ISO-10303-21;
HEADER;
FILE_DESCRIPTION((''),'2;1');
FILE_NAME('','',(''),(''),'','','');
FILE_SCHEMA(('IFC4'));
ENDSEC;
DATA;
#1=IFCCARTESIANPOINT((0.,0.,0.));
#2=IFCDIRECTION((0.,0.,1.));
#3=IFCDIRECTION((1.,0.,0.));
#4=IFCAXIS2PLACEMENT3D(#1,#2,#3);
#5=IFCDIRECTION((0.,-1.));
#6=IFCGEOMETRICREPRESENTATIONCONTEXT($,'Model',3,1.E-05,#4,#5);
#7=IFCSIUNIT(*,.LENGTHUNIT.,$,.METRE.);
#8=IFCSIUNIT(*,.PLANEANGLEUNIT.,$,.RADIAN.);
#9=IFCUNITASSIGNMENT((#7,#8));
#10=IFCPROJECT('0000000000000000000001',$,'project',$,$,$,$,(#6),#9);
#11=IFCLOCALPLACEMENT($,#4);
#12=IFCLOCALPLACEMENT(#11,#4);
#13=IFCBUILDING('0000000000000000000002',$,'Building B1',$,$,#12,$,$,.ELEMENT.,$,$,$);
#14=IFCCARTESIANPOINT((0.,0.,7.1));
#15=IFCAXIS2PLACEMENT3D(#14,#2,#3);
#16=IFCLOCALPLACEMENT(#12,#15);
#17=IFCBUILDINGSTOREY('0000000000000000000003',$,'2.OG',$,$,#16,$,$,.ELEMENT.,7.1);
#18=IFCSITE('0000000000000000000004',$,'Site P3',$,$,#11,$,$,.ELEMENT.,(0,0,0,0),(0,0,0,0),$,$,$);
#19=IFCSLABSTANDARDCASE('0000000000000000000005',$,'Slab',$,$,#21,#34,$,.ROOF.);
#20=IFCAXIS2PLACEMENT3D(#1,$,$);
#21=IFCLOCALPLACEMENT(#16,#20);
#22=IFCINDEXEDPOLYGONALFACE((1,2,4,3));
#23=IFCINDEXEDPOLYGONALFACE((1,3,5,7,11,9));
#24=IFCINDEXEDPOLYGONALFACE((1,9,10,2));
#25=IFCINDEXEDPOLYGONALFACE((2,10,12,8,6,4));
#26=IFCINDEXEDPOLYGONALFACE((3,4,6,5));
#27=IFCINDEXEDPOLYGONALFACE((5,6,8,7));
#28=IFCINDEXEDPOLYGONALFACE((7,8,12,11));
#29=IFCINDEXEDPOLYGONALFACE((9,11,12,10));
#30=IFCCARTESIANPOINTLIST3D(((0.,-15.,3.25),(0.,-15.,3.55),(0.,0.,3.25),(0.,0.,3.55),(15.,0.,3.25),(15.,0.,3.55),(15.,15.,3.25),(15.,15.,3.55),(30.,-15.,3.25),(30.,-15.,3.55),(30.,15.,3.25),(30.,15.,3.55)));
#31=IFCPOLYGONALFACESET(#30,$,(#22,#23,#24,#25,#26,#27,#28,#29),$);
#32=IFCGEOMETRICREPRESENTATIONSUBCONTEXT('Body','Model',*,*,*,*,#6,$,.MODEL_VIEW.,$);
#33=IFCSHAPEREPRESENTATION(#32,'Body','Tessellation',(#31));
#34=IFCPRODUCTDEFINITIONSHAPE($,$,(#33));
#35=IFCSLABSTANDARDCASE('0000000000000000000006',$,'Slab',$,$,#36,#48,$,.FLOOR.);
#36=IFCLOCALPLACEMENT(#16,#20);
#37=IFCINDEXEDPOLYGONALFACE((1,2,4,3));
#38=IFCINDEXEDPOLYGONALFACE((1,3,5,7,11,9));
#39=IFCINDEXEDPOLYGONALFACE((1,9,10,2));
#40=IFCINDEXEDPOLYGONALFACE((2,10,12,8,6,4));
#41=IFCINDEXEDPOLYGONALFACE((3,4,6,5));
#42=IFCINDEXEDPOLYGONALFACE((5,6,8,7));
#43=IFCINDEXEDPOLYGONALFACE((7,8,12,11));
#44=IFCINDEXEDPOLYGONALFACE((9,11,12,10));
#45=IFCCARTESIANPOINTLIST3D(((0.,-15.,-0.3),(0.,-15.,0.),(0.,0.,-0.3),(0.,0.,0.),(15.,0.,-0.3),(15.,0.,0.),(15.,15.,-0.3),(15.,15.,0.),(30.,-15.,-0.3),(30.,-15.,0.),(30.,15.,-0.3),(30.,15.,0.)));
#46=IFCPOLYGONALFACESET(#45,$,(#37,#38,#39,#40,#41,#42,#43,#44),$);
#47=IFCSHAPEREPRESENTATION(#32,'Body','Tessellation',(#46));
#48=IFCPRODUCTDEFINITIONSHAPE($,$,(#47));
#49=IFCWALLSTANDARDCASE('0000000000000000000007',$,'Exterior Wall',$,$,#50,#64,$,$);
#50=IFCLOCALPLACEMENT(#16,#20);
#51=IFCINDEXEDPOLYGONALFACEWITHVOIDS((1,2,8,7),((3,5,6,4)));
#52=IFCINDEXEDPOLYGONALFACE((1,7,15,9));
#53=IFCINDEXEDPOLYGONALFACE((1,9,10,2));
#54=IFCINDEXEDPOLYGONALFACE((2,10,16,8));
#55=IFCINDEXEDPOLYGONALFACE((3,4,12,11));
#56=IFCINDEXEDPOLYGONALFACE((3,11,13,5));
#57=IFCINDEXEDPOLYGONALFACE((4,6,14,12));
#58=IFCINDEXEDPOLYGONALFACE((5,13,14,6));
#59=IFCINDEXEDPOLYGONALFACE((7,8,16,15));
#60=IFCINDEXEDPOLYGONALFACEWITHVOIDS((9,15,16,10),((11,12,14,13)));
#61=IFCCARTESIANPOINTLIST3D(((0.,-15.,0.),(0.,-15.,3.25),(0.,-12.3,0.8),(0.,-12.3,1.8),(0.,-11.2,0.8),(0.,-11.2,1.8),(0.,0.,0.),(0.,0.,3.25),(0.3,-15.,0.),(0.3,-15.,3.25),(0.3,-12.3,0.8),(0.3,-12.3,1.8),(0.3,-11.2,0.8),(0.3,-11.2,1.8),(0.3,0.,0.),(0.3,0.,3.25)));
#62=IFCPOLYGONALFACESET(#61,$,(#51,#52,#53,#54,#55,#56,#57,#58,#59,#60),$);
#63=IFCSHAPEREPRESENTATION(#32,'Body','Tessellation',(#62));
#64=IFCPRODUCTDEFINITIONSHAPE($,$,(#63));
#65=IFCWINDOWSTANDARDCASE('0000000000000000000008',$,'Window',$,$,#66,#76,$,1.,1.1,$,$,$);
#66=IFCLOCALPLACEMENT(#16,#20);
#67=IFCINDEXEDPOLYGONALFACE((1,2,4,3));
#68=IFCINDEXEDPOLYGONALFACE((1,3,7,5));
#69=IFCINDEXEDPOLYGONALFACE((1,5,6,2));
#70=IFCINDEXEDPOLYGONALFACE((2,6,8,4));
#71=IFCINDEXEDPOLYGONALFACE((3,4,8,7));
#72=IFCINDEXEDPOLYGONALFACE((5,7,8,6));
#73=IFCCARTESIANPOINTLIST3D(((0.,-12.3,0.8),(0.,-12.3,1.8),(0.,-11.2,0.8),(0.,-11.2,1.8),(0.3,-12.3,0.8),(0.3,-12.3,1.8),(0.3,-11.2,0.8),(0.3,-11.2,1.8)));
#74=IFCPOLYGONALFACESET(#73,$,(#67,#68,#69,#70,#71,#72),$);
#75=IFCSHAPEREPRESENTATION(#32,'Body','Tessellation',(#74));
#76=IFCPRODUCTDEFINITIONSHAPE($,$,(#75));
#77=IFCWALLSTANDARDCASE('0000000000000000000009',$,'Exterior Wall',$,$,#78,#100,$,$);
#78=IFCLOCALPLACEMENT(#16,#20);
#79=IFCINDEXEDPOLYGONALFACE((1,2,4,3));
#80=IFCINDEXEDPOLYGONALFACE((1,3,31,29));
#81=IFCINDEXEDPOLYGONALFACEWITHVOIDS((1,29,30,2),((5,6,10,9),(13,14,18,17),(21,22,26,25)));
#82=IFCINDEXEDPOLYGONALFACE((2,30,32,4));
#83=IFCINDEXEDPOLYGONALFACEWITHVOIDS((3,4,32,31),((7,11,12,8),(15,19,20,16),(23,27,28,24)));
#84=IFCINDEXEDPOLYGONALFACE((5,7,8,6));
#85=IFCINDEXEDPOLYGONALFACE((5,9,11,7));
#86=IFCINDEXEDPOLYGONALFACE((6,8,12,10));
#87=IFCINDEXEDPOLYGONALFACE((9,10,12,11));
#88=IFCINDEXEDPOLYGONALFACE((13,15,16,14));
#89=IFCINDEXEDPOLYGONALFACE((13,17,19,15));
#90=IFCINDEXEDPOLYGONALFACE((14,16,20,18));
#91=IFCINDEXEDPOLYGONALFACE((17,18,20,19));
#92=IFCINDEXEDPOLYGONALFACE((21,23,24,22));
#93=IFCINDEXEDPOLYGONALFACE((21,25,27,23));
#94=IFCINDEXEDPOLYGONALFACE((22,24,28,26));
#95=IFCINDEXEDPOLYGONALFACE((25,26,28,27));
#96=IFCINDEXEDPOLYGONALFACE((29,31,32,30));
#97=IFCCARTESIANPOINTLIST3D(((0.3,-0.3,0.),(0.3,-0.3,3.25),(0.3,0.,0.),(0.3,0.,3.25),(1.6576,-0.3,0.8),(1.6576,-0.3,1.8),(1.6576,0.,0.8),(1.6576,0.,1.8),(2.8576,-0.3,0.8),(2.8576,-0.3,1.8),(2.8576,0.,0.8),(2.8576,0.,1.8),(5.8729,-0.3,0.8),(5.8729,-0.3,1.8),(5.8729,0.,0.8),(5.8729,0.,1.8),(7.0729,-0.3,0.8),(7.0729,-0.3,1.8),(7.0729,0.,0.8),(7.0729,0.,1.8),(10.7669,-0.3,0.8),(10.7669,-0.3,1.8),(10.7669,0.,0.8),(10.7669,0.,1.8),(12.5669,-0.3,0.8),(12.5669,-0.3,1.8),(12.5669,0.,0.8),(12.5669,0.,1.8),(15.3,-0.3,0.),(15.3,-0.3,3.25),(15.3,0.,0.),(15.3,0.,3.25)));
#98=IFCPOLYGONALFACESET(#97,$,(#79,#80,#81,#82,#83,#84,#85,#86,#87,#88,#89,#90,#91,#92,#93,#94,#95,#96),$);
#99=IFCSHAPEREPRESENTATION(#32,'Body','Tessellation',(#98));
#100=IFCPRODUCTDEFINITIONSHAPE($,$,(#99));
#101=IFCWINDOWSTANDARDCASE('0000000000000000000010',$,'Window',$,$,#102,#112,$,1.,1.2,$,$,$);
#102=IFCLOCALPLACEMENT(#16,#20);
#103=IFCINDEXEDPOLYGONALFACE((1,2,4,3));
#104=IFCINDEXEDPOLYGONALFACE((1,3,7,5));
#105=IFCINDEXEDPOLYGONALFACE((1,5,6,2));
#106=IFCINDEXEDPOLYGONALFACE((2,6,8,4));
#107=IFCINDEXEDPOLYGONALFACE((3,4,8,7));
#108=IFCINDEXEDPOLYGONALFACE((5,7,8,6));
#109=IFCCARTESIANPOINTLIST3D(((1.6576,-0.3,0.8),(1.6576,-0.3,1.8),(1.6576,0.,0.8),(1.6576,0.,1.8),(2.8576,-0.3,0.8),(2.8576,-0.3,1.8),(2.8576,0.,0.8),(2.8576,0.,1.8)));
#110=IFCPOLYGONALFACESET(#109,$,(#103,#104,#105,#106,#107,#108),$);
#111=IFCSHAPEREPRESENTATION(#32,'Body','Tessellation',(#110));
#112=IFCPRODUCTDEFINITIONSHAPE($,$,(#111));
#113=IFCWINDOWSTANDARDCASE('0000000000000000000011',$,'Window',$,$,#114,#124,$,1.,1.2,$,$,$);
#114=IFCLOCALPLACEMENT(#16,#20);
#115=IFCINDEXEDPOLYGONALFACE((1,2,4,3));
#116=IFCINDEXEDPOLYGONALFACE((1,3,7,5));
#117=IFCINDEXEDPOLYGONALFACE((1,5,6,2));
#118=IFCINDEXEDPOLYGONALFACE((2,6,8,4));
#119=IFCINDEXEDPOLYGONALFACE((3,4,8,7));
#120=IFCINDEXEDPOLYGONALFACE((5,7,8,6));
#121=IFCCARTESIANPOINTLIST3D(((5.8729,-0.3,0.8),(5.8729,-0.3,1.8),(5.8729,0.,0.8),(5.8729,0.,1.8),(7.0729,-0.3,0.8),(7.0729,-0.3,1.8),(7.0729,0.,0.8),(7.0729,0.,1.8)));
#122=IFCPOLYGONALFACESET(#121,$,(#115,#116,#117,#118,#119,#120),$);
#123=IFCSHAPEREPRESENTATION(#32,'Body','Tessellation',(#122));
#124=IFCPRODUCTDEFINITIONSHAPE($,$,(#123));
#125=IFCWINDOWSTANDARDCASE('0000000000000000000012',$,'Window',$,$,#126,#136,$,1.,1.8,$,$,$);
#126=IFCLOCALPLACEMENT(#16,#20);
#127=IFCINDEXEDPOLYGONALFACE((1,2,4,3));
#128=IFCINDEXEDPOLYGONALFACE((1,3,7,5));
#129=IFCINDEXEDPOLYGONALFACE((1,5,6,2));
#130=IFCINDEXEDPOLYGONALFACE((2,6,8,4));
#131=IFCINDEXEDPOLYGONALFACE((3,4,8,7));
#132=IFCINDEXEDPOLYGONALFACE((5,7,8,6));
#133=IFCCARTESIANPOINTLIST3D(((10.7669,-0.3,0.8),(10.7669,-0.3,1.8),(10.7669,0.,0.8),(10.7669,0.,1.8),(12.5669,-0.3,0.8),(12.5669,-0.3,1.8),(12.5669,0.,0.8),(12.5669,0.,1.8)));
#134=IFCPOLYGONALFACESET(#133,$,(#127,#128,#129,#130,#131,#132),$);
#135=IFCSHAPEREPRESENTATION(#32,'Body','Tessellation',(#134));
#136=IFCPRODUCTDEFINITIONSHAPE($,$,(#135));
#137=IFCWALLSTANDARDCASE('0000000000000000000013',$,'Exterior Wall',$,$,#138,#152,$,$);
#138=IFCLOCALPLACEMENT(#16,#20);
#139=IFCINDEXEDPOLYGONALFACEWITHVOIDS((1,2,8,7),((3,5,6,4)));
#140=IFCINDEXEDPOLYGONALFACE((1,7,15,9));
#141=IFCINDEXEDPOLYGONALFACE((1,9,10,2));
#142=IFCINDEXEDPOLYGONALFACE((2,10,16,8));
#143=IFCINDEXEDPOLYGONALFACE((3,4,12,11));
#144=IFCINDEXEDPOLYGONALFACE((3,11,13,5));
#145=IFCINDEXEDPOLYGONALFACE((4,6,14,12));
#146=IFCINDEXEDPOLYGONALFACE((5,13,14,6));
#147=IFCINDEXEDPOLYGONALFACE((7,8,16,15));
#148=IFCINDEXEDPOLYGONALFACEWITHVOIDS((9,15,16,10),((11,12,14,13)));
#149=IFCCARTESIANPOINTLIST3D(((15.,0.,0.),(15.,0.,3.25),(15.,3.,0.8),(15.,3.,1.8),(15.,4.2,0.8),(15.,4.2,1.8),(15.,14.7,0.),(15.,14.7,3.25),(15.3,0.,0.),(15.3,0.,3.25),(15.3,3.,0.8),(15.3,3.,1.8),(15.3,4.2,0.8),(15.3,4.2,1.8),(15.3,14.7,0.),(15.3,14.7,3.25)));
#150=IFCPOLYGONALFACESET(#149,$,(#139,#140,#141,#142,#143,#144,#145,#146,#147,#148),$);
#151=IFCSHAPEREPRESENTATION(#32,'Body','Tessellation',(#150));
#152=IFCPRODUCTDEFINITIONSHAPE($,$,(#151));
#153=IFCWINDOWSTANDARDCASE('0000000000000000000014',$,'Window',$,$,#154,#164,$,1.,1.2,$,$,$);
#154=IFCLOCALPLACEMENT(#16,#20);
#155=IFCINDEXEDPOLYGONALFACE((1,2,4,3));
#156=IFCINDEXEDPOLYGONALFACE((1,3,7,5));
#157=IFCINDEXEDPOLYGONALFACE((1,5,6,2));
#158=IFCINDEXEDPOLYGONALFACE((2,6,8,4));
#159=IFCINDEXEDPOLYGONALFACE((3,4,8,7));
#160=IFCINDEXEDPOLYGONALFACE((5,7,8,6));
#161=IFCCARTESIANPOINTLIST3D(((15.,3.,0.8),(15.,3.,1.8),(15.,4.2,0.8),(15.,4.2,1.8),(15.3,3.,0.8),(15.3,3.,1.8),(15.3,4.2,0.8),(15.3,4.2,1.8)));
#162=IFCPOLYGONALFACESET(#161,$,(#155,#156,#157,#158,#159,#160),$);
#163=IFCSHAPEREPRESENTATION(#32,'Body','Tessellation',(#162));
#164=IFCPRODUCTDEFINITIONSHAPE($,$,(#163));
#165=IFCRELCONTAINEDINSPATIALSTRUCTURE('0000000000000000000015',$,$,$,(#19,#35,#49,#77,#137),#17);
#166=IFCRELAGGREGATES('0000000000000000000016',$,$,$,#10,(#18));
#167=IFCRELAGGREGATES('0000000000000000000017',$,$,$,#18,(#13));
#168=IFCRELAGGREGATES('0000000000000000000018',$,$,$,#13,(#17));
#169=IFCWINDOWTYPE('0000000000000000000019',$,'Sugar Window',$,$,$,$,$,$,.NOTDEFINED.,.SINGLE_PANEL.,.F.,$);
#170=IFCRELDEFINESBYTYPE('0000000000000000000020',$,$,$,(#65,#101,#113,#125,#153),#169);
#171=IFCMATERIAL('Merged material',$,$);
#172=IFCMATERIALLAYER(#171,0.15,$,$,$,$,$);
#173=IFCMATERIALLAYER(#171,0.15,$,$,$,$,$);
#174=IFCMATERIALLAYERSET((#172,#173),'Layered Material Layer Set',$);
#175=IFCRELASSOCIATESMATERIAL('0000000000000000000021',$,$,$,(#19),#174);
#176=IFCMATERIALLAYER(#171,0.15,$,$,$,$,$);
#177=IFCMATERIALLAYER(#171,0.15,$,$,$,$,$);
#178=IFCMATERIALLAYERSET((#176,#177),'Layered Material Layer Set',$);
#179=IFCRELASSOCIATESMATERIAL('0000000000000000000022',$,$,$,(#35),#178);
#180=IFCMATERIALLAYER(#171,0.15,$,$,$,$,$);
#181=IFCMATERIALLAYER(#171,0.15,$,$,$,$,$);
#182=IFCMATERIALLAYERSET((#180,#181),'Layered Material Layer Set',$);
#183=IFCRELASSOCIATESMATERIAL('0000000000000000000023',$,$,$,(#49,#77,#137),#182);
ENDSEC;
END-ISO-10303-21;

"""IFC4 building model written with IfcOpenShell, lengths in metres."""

from ifc_helpers import new_model, si_unit, direction, frame, origin_with_axes, place, context, subcontext, project, spatial, polyline, outline, extrude, source, transform, mapped, material, layer, layer_set, layer_usage, type_object, element, fill, save


model = new_model("IFC4")

# Units and contexts
model_context = context("Model", 3, precision=1e-05, world=origin_with_axes(), true_north=direction((0.0, -1.0)))
body_context = subcontext(model_context, "Body", "Model", "MODEL_VIEW")
ifc_project = project(units=[si_unit("LENGTHUNIT", "METRE"), si_unit("PLANEANGLEUNIT", "RADIAN")], contexts=[model_context])

# Site, building, storey
site_placement = place(None, origin_with_axes())
site = spatial("IfcSite", under=ifc_project, at=site_placement, Name="Site P3", CompositionType="ELEMENT", RefLatitude=(0, 0, 0, 0), RefLongitude=(0, 0, 0, 0))
building_placement = place(site_placement, origin_with_axes())
building = spatial("IfcBuilding", under=site, at=building_placement, Name="Building B1", CompositionType="ELEMENT")
storey_placement = place(building_placement, frame((0.0, 0.0, 7.1), z_axis=(0.0, 0.0, 1.0), x_axis=(1.0, 0.0, 0.0)))
storey = spatial("IfcBuildingStorey", under=building, at=storey_placement, Name="2.OG", CompositionType="ELEMENT", Elevation=7.1)

# Slabs
ifc_material = material(Name="Merged material")
ifc_layer_1 = layer(ifc_material, 0.15)
ifc_layer_2 = layer(ifc_material, 0.15)
ifc_layer_set_1 = layer_set([ifc_layer_1, ifc_layer_2], Name="Layered Material Layer Set")
ifc_layer_usage_1 = layer_usage(ifc_layer_set_1, "AXIS2", "POSITIVE", -0.15)
slab_1_placement = place(storey_placement, frame((0.0, 0.0, 3.55), z_axis=(0.0, 0.0, 1.0), x_axis=(1.0, 0.0, 0.0)))
element("IfcSlabStandardCase", 1, at=slab_1_placement, inside=storey, material=ifc_layer_usage_1, Name="Slab", PredefinedType="ROOF", context=body_context, shape_type="SweptSolid", body=[
    extrude(outline(polyline([(0.0, -15.0), (30.0, -15.0), (30.0, 15.0), (15.0, 15.0), (15.0, 0.0), (0.0, 0.0), (0.0, -15.0)])), frame((0.0, 0.0, -0.3), z_axis=(0.0, 0.0, 1.0), x_axis=(1.0, 0.0, 0.0)), (0.0, 0.0, 1.0), 0.3),
])
ifc_layer_3 = layer(ifc_material, 0.15)
ifc_layer_4 = layer(ifc_material, 0.15)
ifc_layer_set_2 = layer_set([ifc_layer_3, ifc_layer_4], Name="Layered Material Layer Set")
ifc_layer_usage_2 = layer_usage(ifc_layer_set_2, "AXIS2", "POSITIVE", -0.15)
slab_2_placement = place(storey_placement, origin_with_axes())
element("IfcSlabStandardCase", 2, at=slab_2_placement, inside=storey, material=ifc_layer_usage_2, Name="Slab", PredefinedType="FLOOR", context=body_context, shape_type="SweptSolid", body=[
    extrude(outline(polyline([(0.0, -15.0), (30.0, -15.0), (30.0, 15.0), (15.0, 15.0), (15.0, 0.0), (0.0, 0.0), (0.0, -15.0)])), frame((0.0, 0.0, -0.3), z_axis=(0.0, 0.0, 1.0), x_axis=(1.0, 0.0, 0.0)), (0.0, 0.0, 1.0), 0.3),
])

# Wall, opening, window
ifc_layer_5 = layer(ifc_material, 0.15)
ifc_layer_6 = layer(ifc_material, 0.15)
ifc_layer_set_3 = layer_set([ifc_layer_5, ifc_layer_6], Name="Layered Material Layer Set")
ifc_layer_usage_3 = layer_usage(ifc_layer_set_3, "AXIS2", "POSITIVE", -0.15)
wall_1_placement = place(storey_placement, frame((0.15, 0.0, 0.0), z_axis=(0.0, 0.0, 1.0), x_axis=(0.0, -1.0, 0.0)))
wall_1 = element("IfcWallStandardCase", 3, at=wall_1_placement, inside=storey, material=ifc_layer_usage_3, Name="Exterior Wall", context=body_context, shape_type="SweptSolid", body=[
    extrude(outline(polyline([(0.0, 0.15), (15.0, 0.15), (15.0, -0.15), (0.0, -0.15), (0.0, 0.15)])), origin_with_axes(), (0.0, 0.0, 1.0), 3.25),
])
opening_1_placement = place(wall_1_placement, frame((11.2, 0.0, 0.8), z_axis=(0.0, 0.0, 1.0), x_axis=(1.0, 0.0, 0.0)))
opening_1 = element("IfcOpeningStandardCase", 4, at=opening_1_placement, cuts=wall_1, context=body_context, shape_type="SweptSolid", body=[
    extrude(outline(polyline([(0.0, 0.0), (0.0, 1.1), (1.0, 1.1), (1.0, 0.0), (0.0, 0.0)])), frame((0.0, -0.15, 0.0), z_axis=(0.0, 1.0, 0.0), x_axis=(0.0, 0.0, 1.0)), (0.0, 0.0, 1.0), 0.3),
])
window_type = type_object("IfcWindowType", Name="Sugar Window", ParameterTakesPrecedence=False, PartitioningType="SINGLE_PANEL", PredefinedType="NOTDEFINED")
shared_shape_1 = source(origin_with_axes(), body_context, "Body", "SweptSolid", [
    extrude(outline(polyline([(0.0, 0.0), (0.0, 1.1), (1.0, 1.1), (1.0, 0.0), (0.0, 0.0)])), frame((0.0, -0.15, 0.0), z_axis=(0.0, 1.0, 0.0), x_axis=(0.0, 0.0, 1.0)), (0.0, 0.0, 1.0), 0.3),
])
window_1_placement = place(opening_1_placement, origin_with_axes())
window_1 = element("IfcWindowStandardCase", 5, at=window_1_placement, type_object=window_type, Name="Window", OverallHeight=1.0, OverallWidth=1.1, context=body_context, shape_type="MappedRepresentation", body=[
    mapped(shared_shape_1, transform((0.0, 0.0, 0.0))),
])
fill(opening_1, window_1)

# Wall, openings, windows
wall_2_placement = place(storey_placement, frame((15.3, -0.15, 0.0), z_axis=(0.0, 0.0, 1.0), x_axis=(-1.0, 0.0, 0.0)))
wall_2 = element("IfcWallStandardCase", 6, at=wall_2_placement, inside=storey, material=ifc_layer_usage_3, Name="Exterior Wall", context=body_context, shape_type="SweptSolid", body=[
    extrude(outline(polyline([(0.0, 0.15), (15.0, 0.15), (15.0, -0.15), (0.0, -0.15), (0.0, 0.15)])), origin_with_axes(), (0.0, 0.0, 1.0), 3.25),
])
opening_2_placement = place(wall_2_placement, frame((12.4424, 0.0, 0.8), z_axis=(0.0, 0.0, 1.0), x_axis=(1.0, 0.0, 0.0)))
opening_2 = element("IfcOpeningStandardCase", 7, at=opening_2_placement, cuts=wall_2, context=body_context, shape_type="SweptSolid", body=[
    extrude(outline(polyline([(0.0, 0.0), (0.0, 1.2), (1.0, 1.2), (1.0, 0.0), (0.0, 0.0)])), frame((0.0, -0.15, 0.0), z_axis=(0.0, 1.0, 0.0), x_axis=(0.0, 0.0, 1.0)), (0.0, 0.0, 1.0), 0.3),
])
opening_3_placement = place(wall_2_placement, frame((8.2271, 0.0, 0.8), z_axis=(0.0, 0.0, 1.0), x_axis=(1.0, 0.0, 0.0)))
opening_3 = element("IfcOpeningStandardCase", 8, at=opening_3_placement, cuts=wall_2, context=body_context, shape_type="SweptSolid", body=[
    extrude(outline(polyline([(0.0, 0.0), (0.0, 1.2), (1.0, 1.2), (1.0, 0.0), (0.0, 0.0)])), frame((0.0, -0.15, 0.0), z_axis=(0.0, 1.0, 0.0), x_axis=(0.0, 0.0, 1.0)), (0.0, 0.0, 1.0), 0.3),
])
opening_4_placement = place(wall_2_placement, frame((2.7331, 0.0, 0.8), z_axis=(0.0, 0.0, 1.0), x_axis=(1.0, 0.0, 0.0)))
opening_4 = element("IfcOpeningStandardCase", 9, at=opening_4_placement, cuts=wall_2, context=body_context, shape_type="SweptSolid", body=[
    extrude(outline(polyline([(0.0, 0.0), (0.0, 1.8), (1.0, 1.8), (1.0, 0.0), (0.0, 0.0)])), frame((0.0, -0.15, 0.0), z_axis=(0.0, 1.0, 0.0), x_axis=(0.0, 0.0, 1.0)), (0.0, 0.0, 1.0), 0.3),
])
shared_shape_2 = source(origin_with_axes(), body_context, "Body", "SweptSolid", [
    extrude(outline(polyline([(0.0, 0.0), (0.0, 1.2), (1.0, 1.2), (1.0, 0.0), (0.0, 0.0)])), frame((0.0, -0.15, 0.0), z_axis=(0.0, 1.0, 0.0), x_axis=(0.0, 0.0, 1.0)), (0.0, 0.0, 1.0), 0.3),
])
window_2_placement = place(opening_2_placement, origin_with_axes())
window_2 = element("IfcWindowStandardCase", 10, at=window_2_placement, type_object=window_type, Name="Window", OverallHeight=1.0, OverallWidth=1.2, context=body_context, shape_type="MappedRepresentation", body=[
    mapped(shared_shape_2, transform((0.0, 0.0, 0.0))),
])
fill(opening_2, window_2)
window_3_placement = place(opening_3_placement, origin_with_axes())
window_3 = element("IfcWindowStandardCase", 11, at=window_3_placement, type_object=window_type, Name="Window", OverallHeight=1.0, OverallWidth=1.2, context=body_context, shape_type="MappedRepresentation", body=[
    mapped(shared_shape_2, transform((0.0, 0.0, 0.0))),
])
fill(opening_3, window_3)
shared_shape_3 = source(origin_with_axes(), body_context, "Body", "SweptSolid", [
    extrude(outline(polyline([(0.0, 0.0), (0.0, 1.8), (1.0, 1.8), (1.0, 0.0), (0.0, 0.0)])), frame((0.0, -0.15, 0.0), z_axis=(0.0, 1.0, 0.0), x_axis=(0.0, 0.0, 1.0)), (0.0, 0.0, 1.0), 0.3),
])
window_4_placement = place(opening_4_placement, origin_with_axes())
window_4 = element("IfcWindowStandardCase", 12, at=window_4_placement, type_object=window_type, Name="Window", OverallHeight=1.0, OverallWidth=1.8, context=body_context, shape_type="MappedRepresentation", body=[
    mapped(shared_shape_3, transform((0.0, 0.0, 0.0))),
])
fill(opening_4, window_4)

# Wall, opening, window
wall_3_placement = place(storey_placement, frame((15.15, 14.7, 0.0), z_axis=(0.0, 0.0, 1.0), x_axis=(0.0, -1.0, 0.0)))
wall_3 = element("IfcWallStandardCase", 13, at=wall_3_placement, inside=storey, material=ifc_layer_usage_3, Name="Exterior Wall", context=body_context, shape_type="SweptSolid", body=[
    extrude(outline(polyline([(0.0, 0.15), (14.7, 0.15), (14.7, -0.15), (0.0, -0.15), (0.0, 0.15)])), origin_with_axes(), (0.0, 0.0, 1.0), 3.25),
])
opening_5_placement = place(wall_3_placement, frame((10.5, 0.0, 0.8), z_axis=(0.0, 0.0, 1.0), x_axis=(1.0, 0.0, 0.0)))
opening_5 = element("IfcOpeningStandardCase", 14, at=opening_5_placement, cuts=wall_3, context=body_context, shape_type="SweptSolid", body=[
    extrude(outline(polyline([(0.0, 0.0), (0.0, 1.2), (1.0, 1.2), (1.0, 0.0), (0.0, 0.0)])), frame((0.0, -0.15, 0.0), z_axis=(0.0, 1.0, 0.0), x_axis=(0.0, 0.0, 1.0)), (0.0, 0.0, 1.0), 0.3),
])
window_5_placement = place(opening_5_placement, origin_with_axes())
window_5 = element("IfcWindowStandardCase", 15, at=window_5_placement, type_object=window_type, Name="Window", OverallHeight=1.0, OverallWidth=1.2, context=body_context, shape_type="MappedRepresentation", body=[
    mapped(shared_shape_2, transform((0.0, 0.0, 0.0))),
])
fill(opening_5, window_5)

save(model, "model.ifc")
